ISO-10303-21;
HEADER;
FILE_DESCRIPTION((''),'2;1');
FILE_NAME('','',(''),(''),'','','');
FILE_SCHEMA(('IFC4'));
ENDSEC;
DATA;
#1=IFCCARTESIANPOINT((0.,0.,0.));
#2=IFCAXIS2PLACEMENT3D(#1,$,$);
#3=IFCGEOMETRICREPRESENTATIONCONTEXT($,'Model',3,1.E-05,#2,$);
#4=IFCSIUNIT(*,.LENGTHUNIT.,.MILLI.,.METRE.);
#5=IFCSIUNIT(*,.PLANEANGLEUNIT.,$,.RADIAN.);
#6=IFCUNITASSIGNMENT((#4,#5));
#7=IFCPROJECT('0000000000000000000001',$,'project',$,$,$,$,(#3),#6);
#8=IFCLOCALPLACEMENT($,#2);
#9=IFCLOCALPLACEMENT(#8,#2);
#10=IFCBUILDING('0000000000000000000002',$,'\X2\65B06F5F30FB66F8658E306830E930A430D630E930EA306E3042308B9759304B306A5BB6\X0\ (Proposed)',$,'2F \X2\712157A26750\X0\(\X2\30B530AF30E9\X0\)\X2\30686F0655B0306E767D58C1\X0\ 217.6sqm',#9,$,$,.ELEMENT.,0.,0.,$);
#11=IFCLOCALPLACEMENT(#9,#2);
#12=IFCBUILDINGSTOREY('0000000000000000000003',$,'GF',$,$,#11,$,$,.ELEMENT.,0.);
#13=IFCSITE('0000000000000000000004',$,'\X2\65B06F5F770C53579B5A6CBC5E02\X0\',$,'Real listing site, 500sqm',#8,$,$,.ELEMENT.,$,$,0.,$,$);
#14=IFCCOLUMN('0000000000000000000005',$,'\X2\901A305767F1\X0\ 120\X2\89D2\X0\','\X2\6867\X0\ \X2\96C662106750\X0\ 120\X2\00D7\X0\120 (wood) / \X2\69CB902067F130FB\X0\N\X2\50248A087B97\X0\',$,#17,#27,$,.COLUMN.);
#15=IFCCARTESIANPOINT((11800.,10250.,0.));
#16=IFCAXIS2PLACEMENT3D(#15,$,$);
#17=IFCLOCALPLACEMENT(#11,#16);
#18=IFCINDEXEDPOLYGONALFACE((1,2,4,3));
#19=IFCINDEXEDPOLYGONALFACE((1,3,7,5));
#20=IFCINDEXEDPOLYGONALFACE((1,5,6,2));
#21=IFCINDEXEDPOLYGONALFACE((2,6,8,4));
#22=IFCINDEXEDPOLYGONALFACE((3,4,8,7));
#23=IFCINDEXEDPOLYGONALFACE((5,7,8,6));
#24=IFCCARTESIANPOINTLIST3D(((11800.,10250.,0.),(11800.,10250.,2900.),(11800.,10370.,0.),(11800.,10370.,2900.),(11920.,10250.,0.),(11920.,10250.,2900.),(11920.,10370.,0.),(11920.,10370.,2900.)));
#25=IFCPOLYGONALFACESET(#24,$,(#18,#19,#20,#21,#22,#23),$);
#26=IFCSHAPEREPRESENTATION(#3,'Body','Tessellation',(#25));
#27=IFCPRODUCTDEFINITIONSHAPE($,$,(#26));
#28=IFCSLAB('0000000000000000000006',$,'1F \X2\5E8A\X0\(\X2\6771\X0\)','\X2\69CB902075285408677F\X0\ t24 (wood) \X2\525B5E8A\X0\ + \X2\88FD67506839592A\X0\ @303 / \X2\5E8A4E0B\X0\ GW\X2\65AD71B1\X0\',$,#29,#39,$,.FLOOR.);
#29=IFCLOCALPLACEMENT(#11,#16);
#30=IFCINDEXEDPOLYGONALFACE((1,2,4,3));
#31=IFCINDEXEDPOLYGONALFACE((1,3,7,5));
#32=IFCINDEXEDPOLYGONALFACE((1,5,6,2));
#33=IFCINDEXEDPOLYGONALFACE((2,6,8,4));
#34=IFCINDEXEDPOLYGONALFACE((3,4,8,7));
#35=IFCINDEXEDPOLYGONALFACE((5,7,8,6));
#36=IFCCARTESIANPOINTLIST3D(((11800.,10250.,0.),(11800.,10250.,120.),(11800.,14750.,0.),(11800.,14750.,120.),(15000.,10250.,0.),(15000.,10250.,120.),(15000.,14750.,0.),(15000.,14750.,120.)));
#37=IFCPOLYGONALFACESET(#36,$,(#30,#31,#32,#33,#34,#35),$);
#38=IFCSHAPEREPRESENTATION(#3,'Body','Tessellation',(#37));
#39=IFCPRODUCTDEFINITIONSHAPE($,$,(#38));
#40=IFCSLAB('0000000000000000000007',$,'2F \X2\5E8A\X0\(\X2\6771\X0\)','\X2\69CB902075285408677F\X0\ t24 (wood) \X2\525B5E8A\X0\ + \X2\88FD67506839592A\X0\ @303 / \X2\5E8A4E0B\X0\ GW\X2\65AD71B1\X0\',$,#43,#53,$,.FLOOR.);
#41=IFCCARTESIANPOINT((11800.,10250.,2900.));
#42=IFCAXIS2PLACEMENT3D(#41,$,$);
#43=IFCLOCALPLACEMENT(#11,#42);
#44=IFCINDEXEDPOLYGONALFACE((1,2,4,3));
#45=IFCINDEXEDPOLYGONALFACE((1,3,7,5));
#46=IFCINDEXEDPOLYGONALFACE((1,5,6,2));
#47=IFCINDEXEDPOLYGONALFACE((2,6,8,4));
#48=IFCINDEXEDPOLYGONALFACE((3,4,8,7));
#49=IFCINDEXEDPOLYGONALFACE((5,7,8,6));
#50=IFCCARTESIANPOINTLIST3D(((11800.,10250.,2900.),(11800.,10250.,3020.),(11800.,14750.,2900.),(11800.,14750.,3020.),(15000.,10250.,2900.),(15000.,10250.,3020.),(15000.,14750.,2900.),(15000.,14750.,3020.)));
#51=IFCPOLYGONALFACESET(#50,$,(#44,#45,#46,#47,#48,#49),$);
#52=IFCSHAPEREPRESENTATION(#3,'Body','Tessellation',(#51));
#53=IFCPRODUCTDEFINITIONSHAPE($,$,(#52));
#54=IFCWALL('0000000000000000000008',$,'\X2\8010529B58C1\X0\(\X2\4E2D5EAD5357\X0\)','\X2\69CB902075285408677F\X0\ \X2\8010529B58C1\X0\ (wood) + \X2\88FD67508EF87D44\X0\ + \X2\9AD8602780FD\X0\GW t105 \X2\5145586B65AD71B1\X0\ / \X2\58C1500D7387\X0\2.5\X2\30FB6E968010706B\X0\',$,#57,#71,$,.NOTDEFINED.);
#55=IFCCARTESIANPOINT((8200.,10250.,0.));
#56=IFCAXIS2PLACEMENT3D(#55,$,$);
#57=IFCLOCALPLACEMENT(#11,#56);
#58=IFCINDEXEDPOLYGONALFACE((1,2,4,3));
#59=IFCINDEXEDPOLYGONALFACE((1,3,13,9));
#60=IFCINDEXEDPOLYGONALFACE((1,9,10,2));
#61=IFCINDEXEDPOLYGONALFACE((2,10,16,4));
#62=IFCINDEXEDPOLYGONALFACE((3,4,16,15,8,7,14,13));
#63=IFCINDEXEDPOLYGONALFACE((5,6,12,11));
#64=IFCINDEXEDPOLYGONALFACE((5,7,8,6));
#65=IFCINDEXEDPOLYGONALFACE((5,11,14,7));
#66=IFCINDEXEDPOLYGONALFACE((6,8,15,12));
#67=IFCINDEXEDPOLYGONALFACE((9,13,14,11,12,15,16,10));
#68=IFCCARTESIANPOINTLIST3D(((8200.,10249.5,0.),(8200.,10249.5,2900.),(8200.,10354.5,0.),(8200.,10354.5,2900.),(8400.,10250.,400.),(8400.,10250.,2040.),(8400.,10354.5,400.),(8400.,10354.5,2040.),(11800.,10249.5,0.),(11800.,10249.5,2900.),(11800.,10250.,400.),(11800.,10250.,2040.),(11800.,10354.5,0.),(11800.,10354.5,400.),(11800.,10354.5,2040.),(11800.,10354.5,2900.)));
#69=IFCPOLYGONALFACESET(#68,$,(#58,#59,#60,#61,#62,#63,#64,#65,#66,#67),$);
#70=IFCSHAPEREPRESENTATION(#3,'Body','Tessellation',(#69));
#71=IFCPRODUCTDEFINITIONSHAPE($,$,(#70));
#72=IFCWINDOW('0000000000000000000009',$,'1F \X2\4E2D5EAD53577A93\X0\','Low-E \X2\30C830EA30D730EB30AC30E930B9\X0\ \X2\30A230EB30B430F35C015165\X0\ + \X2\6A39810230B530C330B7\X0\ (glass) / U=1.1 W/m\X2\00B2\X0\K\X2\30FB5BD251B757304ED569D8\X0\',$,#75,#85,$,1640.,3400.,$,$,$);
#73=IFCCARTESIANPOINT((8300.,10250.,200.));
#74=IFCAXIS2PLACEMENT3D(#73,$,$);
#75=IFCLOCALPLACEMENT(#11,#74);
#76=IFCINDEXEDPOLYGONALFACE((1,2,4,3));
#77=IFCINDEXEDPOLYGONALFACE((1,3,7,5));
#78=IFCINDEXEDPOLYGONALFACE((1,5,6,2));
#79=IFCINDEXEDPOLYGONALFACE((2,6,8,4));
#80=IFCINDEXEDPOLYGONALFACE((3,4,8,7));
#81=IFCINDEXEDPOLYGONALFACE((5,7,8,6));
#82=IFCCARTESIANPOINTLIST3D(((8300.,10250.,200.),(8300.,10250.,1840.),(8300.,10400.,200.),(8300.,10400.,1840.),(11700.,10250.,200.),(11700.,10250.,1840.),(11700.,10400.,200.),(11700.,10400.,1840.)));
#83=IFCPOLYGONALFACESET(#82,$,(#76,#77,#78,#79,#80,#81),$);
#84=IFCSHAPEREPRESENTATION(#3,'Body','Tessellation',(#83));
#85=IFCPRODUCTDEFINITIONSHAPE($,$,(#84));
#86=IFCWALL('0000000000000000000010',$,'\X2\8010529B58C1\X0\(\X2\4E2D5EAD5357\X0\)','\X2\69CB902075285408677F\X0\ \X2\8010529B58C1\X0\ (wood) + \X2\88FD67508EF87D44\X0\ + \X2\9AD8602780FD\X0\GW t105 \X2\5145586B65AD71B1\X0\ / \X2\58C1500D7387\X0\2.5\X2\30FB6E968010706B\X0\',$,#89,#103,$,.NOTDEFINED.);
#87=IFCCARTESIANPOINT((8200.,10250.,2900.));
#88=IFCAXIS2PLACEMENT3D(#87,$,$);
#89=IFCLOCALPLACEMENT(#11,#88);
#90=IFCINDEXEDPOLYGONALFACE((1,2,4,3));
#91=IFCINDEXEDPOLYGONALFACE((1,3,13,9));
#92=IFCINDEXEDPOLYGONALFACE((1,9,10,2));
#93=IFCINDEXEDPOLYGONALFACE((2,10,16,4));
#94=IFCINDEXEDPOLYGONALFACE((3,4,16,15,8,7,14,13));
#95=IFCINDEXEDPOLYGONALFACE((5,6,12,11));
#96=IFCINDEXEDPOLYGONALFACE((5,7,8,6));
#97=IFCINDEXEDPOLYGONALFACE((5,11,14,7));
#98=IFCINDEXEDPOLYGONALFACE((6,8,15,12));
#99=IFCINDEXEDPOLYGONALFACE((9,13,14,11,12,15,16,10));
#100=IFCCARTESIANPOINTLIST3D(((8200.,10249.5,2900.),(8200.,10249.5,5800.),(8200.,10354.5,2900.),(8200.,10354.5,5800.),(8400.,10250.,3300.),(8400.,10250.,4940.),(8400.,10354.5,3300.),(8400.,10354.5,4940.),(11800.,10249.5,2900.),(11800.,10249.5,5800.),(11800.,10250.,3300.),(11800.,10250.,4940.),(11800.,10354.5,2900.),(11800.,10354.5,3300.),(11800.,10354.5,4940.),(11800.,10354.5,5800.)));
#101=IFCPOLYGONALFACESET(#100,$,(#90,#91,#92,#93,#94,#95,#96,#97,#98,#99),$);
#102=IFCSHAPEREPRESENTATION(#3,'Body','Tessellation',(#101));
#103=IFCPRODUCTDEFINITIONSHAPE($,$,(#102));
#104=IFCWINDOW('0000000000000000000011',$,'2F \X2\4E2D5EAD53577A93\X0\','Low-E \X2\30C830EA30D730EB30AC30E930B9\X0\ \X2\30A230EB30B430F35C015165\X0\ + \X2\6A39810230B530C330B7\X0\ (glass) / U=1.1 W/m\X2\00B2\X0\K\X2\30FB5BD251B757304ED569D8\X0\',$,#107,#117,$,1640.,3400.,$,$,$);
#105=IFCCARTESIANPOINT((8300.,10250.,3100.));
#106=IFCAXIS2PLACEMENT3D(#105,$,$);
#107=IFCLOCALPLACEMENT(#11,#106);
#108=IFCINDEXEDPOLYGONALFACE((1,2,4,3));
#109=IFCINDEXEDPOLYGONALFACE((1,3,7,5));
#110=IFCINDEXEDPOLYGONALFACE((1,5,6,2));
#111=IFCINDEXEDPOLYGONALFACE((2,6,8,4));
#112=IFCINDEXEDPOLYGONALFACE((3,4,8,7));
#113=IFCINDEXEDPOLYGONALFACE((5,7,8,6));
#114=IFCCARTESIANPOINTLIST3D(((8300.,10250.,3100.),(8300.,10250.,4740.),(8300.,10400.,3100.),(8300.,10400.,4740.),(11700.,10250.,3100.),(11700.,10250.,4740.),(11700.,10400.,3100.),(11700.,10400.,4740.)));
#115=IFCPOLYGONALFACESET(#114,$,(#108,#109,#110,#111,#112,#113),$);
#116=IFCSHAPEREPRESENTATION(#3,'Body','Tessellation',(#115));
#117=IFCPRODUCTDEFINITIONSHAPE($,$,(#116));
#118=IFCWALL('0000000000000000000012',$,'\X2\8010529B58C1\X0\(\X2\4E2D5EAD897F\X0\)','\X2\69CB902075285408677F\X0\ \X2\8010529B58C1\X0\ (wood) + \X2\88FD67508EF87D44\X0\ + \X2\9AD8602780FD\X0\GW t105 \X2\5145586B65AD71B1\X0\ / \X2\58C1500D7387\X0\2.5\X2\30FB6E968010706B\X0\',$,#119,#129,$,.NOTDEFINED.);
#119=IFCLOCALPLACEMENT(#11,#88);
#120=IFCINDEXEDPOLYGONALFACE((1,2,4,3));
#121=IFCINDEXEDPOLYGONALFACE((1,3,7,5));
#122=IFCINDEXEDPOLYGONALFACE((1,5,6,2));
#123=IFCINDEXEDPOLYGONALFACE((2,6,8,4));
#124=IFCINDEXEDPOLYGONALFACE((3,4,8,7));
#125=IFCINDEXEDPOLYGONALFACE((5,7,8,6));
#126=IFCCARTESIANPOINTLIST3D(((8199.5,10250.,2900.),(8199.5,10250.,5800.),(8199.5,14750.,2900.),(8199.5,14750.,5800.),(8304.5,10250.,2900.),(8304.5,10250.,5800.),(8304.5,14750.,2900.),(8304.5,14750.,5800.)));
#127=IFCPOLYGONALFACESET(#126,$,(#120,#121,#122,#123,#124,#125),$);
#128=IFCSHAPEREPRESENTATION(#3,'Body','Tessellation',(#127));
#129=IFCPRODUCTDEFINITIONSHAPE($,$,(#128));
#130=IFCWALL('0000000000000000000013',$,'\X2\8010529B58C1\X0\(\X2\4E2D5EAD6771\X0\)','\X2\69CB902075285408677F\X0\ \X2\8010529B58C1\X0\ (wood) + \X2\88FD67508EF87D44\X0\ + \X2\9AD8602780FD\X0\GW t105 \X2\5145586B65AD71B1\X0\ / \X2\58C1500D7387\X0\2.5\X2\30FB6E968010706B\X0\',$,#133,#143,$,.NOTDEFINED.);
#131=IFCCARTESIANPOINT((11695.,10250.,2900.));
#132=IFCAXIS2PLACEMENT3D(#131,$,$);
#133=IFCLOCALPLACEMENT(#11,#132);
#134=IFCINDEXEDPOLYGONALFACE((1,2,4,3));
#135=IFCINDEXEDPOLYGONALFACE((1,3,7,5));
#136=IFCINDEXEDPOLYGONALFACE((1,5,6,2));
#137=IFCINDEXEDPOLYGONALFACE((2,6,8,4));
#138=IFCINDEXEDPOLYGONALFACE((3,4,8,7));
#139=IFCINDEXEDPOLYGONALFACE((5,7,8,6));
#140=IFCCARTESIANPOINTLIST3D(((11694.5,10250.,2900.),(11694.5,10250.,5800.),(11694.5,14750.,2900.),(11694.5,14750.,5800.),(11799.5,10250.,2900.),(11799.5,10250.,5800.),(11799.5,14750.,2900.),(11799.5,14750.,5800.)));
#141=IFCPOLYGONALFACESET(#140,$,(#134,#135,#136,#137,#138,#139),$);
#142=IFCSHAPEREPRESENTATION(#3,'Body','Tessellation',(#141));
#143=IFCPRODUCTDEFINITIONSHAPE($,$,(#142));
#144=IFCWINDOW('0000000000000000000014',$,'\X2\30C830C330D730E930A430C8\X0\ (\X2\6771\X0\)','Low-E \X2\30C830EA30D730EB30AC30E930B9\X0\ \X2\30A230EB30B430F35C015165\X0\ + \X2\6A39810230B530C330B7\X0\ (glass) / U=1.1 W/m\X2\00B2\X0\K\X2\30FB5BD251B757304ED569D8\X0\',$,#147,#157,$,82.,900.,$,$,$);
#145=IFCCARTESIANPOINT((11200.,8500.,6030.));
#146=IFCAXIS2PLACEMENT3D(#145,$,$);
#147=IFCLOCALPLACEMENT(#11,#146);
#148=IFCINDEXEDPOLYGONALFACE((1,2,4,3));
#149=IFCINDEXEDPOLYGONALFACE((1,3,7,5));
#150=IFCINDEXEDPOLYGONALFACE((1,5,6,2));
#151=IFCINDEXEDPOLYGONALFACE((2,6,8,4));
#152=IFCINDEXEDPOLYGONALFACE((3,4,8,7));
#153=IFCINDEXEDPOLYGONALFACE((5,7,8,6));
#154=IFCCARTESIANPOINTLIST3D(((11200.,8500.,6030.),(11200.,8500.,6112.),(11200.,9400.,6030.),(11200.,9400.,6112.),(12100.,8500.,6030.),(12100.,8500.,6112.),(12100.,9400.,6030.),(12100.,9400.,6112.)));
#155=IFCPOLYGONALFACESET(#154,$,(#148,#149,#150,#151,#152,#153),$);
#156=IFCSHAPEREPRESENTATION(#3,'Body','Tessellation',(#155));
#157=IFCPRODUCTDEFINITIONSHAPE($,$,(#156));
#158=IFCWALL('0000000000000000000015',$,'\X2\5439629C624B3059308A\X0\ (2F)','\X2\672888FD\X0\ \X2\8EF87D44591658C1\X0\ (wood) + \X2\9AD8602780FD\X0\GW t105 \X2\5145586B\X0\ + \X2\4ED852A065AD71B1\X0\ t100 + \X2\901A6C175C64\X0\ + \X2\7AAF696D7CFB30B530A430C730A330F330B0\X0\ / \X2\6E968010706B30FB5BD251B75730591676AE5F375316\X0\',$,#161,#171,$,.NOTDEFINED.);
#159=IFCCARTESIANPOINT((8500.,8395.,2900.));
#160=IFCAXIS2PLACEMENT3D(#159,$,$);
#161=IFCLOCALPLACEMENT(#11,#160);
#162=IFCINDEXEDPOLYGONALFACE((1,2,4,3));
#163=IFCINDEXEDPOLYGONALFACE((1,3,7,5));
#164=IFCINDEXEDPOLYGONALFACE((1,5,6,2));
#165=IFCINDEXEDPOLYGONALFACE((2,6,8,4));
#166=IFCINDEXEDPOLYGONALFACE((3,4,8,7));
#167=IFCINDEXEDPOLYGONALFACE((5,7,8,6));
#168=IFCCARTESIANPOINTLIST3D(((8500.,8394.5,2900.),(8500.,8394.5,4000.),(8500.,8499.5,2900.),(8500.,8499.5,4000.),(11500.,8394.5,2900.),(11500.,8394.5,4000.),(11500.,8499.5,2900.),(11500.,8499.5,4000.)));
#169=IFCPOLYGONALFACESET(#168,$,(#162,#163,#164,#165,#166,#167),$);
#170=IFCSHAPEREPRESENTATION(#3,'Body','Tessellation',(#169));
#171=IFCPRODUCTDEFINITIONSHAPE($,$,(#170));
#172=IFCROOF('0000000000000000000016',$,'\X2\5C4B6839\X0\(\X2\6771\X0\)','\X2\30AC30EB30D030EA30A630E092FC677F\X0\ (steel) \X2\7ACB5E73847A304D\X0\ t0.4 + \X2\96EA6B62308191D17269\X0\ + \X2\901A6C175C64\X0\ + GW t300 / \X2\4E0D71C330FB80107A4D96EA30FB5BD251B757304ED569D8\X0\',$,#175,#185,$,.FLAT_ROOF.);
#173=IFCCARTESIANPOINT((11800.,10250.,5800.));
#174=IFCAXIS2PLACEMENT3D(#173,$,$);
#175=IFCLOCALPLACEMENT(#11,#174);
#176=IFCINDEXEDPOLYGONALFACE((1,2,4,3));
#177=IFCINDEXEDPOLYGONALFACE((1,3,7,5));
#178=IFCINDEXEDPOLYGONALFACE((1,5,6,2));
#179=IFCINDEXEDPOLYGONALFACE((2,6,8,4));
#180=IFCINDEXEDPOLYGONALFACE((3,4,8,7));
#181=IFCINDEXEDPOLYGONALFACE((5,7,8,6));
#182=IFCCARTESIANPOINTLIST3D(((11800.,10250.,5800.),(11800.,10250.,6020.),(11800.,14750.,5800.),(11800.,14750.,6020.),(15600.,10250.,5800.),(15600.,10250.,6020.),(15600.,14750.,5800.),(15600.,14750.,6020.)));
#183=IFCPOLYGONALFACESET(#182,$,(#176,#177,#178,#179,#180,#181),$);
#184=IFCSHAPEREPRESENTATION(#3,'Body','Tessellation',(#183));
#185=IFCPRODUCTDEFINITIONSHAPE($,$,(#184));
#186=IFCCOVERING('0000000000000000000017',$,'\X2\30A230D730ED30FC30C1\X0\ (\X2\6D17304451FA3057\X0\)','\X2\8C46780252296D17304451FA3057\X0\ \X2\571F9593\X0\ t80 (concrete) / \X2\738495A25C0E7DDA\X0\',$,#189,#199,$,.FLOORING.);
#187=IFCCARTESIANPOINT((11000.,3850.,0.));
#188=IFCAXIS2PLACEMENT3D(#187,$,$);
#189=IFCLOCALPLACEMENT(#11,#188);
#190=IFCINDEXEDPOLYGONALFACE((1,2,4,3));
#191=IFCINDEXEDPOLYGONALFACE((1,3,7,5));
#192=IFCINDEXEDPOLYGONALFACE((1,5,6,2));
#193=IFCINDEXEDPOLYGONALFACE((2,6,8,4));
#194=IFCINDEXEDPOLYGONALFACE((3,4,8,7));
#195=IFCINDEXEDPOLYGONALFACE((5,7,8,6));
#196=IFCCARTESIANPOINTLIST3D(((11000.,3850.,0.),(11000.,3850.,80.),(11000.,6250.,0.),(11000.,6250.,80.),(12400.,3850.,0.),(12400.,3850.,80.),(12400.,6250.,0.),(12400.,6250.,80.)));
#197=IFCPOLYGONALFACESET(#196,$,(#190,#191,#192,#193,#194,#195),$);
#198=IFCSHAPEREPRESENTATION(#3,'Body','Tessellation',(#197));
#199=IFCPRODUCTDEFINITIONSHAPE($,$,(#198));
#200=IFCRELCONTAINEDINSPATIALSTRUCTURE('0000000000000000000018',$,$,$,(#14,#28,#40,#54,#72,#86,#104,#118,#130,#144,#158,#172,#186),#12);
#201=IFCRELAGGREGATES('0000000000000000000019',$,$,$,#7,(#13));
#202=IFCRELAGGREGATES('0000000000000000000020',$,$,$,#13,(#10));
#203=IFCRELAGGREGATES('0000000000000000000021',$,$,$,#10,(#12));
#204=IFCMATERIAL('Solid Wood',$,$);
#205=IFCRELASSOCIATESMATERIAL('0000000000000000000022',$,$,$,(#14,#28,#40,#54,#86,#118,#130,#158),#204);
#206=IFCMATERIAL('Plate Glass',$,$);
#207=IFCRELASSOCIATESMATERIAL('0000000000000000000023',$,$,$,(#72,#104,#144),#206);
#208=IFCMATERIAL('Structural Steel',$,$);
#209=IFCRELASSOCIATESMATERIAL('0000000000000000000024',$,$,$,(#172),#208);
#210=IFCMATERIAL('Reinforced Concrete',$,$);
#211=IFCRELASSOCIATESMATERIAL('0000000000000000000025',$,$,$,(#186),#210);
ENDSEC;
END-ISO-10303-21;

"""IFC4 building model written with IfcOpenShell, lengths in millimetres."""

from ifc_helpers import new_model, si_unit, frame, frame_2d, origin, place, context, project, spatial, rectangle, extrude, material, element, fill, save


model = new_model("IFC4")

# Units and contexts
model_context = context("Model", 3, precision=1e-05, world=origin())
ifc_project = project(units=[si_unit("LENGTHUNIT", "METRE", prefix="MILLI"), si_unit("PLANEANGLEUNIT", "RADIAN")], contexts=[model_context])

# Site, building, storey
site_placement = place(None, origin())
site = spatial("IfcSite", under=ifc_project, at=site_placement, Name="新潟県南魚沼市", ObjectType="Real listing site, 500sqm", CompositionType="ELEMENT", RefElevation=0.0)
building_placement = place(site_placement, origin())
building = spatial("IfcBuilding", under=site, at=building_placement, Name="新潟・書斎とライブラリのある静かな家 (Proposed)", ObjectType="2F 無垢材(サクラ)と漆喰の白壁 217.6sqm", CompositionType="ELEMENT", ElevationOfRefHeight=0.0, ElevationOfTerrain=0.0)
storey_placement = place(building_placement, origin())
storey = spatial("IfcBuildingStorey", under=building, at=storey_placement, Name="GF", CompositionType="ELEMENT", Elevation=0.0)

# Column
ifc_material_1 = material(Name="Solid Wood")
column_1_placement = place(storey_placement, frame((11800.0, 10250.0, 0.0)))
element("IfcColumn", 1, at=column_1_placement, inside=storey, material=ifc_material_1, Name="通し柱 120角", Description="桧 集成材 120×120 (wood) / 構造柱・N値計算", PredefinedType="COLUMN", context=model_context, shape_type="SweptSolid", body=[
    extrude(rectangle(XDim=120.0, YDim=120.0, at=frame_2d((60.0, 60.0))), frame((11800.0, 10250.0, 0.0)), (0.0, 0.0, 1.0), 2900.0),
])

# Slabs
slab_1_placement = place(storey_placement, frame((11800.0, 10250.0, 0.0)))
element("IfcSlab", 2, at=slab_1_placement, inside=storey, material=ifc_material_1, Name="1F 床(東)", Description="構造用合板 t24 (wood) 剛床 + 製材根太 @303 / 床下 GW断熱", PredefinedType="FLOOR", context=model_context, shape_type="SweptSolid", body=[
    extrude(rectangle(XDim=3200.0, YDim=4500.0, at=frame_2d((1600.0, 2250.0))), frame((11800.0, 10250.0, 0.0)), (0.0, 0.0, 1.0), 120.0),
])
slab_2_placement = place(storey_placement, frame((11800.0, 10250.0, 2900.0)))
element("IfcSlab", 3, at=slab_2_placement, inside=storey, material=ifc_material_1, Name="2F 床(東)", Description="構造用合板 t24 (wood) 剛床 + 製材根太 @303 / 床下 GW断熱", PredefinedType="FLOOR", context=model_context, shape_type="SweptSolid", body=[
    extrude(rectangle(XDim=3200.0, YDim=4500.0, at=frame_2d((1600.0, 2250.0))), frame((11800.0, 10250.0, 2900.0)), (0.0, 0.0, 1.0), 120.0),
])

# Wall, opening, window
wall_1_placement = place(storey_placement, frame((8200.0, 10250.0, 0.0)))
wall_1 = element("IfcWall", 4, at=wall_1_placement, inside=storey, material=ifc_material_1, Name="耐力壁(中庭南)", Description="構造用合板 耐力壁 (wood) + 製材軸組 + 高性能GW t105 充填断熱 / 壁倍率2.5・準耐火", PredefinedType="NOTDEFINED", context=model_context, shape_type="SweptSolid", body=[
    extrude(rectangle(XDim=3600.0, YDim=105.0, at=frame_2d((1800.0, 52.0))), frame((8200.0, 10250.0, 0.0)), (0.0, 0.0, 1.0), 2900.0),
])
opening_1_placement = place(storey_placement, frame((8300.0, 10250.0, 200.0)))
opening_1 = element("IfcOpeningElement", 5, at=opening_1_placement, cuts=wall_1, PredefinedType="NOTDEFINED", context=model_context, shape_type="SweptSolid", body=[
    extrude(rectangle(XDim=3400.0, YDim=150.0, at=frame_2d((1700.0, 75.0))), frame((8300.0, 10250.0, 200.0)), (0.0, 0.0, 1.0), 1640.0),
])
ifc_material_2 = material(Name="Plate Glass")
window_1_placement = place(storey_placement, frame((8300.0, 10250.0, 200.0)))
window_1 = element("IfcWindow", 6, at=window_1_placement, inside=storey, material=ifc_material_2, Name="1F 中庭南窓", Description="Low-E トリプルガラス アルゴン封入 + 樹脂サッシ (glass) / U=1.1 W/m²K・寒冷地仕様", OverallHeight=1640.0, OverallWidth=3400.0, context=model_context, shape_type="SweptSolid", body=[
    extrude(rectangle(XDim=3400.0, YDim=150.0, at=frame_2d((1700.0, 75.0))), frame((8300.0, 10250.0, 200.0)), (0.0, 0.0, 1.0), 1640.0),
])
fill(opening_1, window_1)

# Wall, opening, window
wall_2_placement = place(storey_placement, frame((8200.0, 10250.0, 2900.0)))
wall_2 = element("IfcWall", 7, at=wall_2_placement, inside=storey, material=ifc_material_1, Name="耐力壁(中庭南)", Description="構造用合板 耐力壁 (wood) + 製材軸組 + 高性能GW t105 充填断熱 / 壁倍率2.5・準耐火", PredefinedType="NOTDEFINED", context=model_context, shape_type="SweptSolid", body=[
    extrude(rectangle(XDim=3600.0, YDim=105.0, at=frame_2d((1800.0, 52.0))), frame((8200.0, 10250.0, 2900.0)), (0.0, 0.0, 1.0), 2900.0),
])
opening_2_placement = place(storey_placement, frame((8300.0, 10250.0, 3100.0)))
opening_2 = element("IfcOpeningElement", 8, at=opening_2_placement, cuts=wall_2, PredefinedType="NOTDEFINED", context=model_context, shape_type="SweptSolid", body=[
    extrude(rectangle(XDim=3400.0, YDim=150.0, at=frame_2d((1700.0, 75.0))), frame((8300.0, 10250.0, 3100.0)), (0.0, 0.0, 1.0), 1640.0),
])
window_2_placement = place(storey_placement, frame((8300.0, 10250.0, 3100.0)))
window_2 = element("IfcWindow", 9, at=window_2_placement, inside=storey, material=ifc_material_2, Name="2F 中庭南窓", Description="Low-E トリプルガラス アルゴン封入 + 樹脂サッシ (glass) / U=1.1 W/m²K・寒冷地仕様", OverallHeight=1640.0, OverallWidth=3400.0, context=model_context, shape_type="SweptSolid", body=[
    extrude(rectangle(XDim=3400.0, YDim=150.0, at=frame_2d((1700.0, 75.0))), frame((8300.0, 10250.0, 3100.0)), (0.0, 0.0, 1.0), 1640.0),
])
fill(opening_2, window_2)

# Walls
wall_3_placement = place(storey_placement, frame((8200.0, 10250.0, 2900.0)))
element("IfcWall", 10, at=wall_3_placement, inside=storey, material=ifc_material_1, Name="耐力壁(中庭西)", Description="構造用合板 耐力壁 (wood) + 製材軸組 + 高性能GW t105 充填断熱 / 壁倍率2.5・準耐火", PredefinedType="NOTDEFINED", context=model_context, shape_type="SweptSolid", body=[
    extrude(rectangle(XDim=105.0, YDim=4500.0, at=frame_2d((52.0, 2250.0))), frame((8200.0, 10250.0, 2900.0)), (0.0, 0.0, 1.0), 2900.0),
])
wall_4_placement = place(storey_placement, frame((11695.0, 10250.0, 2900.0)))
element("IfcWall", 11, at=wall_4_placement, inside=storey, material=ifc_material_1, Name="耐力壁(中庭東)", Description="構造用合板 耐力壁 (wood) + 製材軸組 + 高性能GW t105 充填断熱 / 壁倍率2.5・準耐火", PredefinedType="NOTDEFINED", context=model_context, shape_type="SweptSolid", body=[
    extrude(rectangle(XDim=105.0, YDim=4500.0, at=frame_2d((52.0, 2250.0))), frame((11695.0, 10250.0, 2900.0)), (0.0, 0.0, 1.0), 2900.0),
])

# Window
window_3_placement = place(storey_placement, frame((11200.0, 8500.0, 6030.0)))
element("IfcWindow", 12, at=window_3_placement, inside=storey, material=ifc_material_2, Name="トップライト (東)", Description="Low-E トリプルガラス アルゴン封入 + 樹脂サッシ (glass) / U=1.1 W/m²K・寒冷地仕様", OverallHeight=82.0, OverallWidth=900.0, context=model_context, shape_type="SweptSolid", body=[
    extrude(rectangle(XDim=900.0, YDim=900.0, at=frame_2d((450.0, 450.0))), frame((11200.0, 8500.0, 6030.0)), (0.0, 0.0, 1.0), 82.0),
])

# Wall
wall_5_placement = place(storey_placement, frame((8500.0, 8395.0, 2900.0)))
element("IfcWall", 13, at=wall_5_placement, inside=storey, material=ifc_material_1, Name="吹抜手すり (2F)", Description="木製 軸組外壁 (wood) + 高性能GW t105 充填 + 付加断熱 t100 + 通気層 + 窯業系サイディング / 準耐火・寒冷地外皮強化", PredefinedType="NOTDEFINED", context=model_context, shape_type="SweptSolid", body=[
    extrude(rectangle(XDim=3000.0, YDim=105.0, at=frame_2d((1500.0, 52.0))), frame((8500.0, 8395.0, 2900.0)), (0.0, 0.0, 1.0), 1100.0),
])

# Roof
ifc_material_3 = material(Name="Structural Steel")
for number, where, name in (
    (14, (11800.0, 10250.0, 5800.0), "屋根(東)"),
):
    element("IfcRoof", number, at=place(storey_placement, frame(where)), inside=storey, material=ifc_material_3, Name=name, Description="ガルバリウム鋼板 (steel) 立平葺き t0.4 + 雪止め金物 + 通気層 + GW t300 / 不燃・耐積雪・寒冷地仕様", PredefinedType="FLAT_ROOF", context=model_context, shape_type="SweptSolid", body=[
        extrude(rectangle(XDim=3800.0, YDim=4500.0, at=frame_2d((1900.0, 2250.0))), frame((11800.0, 10250.0, 5800.0)), (0.0, 0.0, 1.0), 220.0),
    ])

# Covering
ifc_material_4 = material(Name="Reinforced Concrete")
covering_placement = place(storey_placement, frame((11000.0, 3850.0, 0.0)))
element("IfcCovering", 15, at=covering_placement, inside=storey, material=ifc_material_4, Name="アプローチ (洗い出し)", Description="豆砂利洗い出し 土間 t80 (concrete) / 玄関導線", PredefinedType="FLOORING", context=model_context, shape_type="SweptSolid", body=[
    extrude(rectangle(XDim=1400.0, YDim=2400.0, at=frame_2d((700.0, 1200.0))), frame((11000.0, 3850.0, 0.0)), (0.0, 0.0, 1.0), 80.0),
])

save(model, "model.ifc")
